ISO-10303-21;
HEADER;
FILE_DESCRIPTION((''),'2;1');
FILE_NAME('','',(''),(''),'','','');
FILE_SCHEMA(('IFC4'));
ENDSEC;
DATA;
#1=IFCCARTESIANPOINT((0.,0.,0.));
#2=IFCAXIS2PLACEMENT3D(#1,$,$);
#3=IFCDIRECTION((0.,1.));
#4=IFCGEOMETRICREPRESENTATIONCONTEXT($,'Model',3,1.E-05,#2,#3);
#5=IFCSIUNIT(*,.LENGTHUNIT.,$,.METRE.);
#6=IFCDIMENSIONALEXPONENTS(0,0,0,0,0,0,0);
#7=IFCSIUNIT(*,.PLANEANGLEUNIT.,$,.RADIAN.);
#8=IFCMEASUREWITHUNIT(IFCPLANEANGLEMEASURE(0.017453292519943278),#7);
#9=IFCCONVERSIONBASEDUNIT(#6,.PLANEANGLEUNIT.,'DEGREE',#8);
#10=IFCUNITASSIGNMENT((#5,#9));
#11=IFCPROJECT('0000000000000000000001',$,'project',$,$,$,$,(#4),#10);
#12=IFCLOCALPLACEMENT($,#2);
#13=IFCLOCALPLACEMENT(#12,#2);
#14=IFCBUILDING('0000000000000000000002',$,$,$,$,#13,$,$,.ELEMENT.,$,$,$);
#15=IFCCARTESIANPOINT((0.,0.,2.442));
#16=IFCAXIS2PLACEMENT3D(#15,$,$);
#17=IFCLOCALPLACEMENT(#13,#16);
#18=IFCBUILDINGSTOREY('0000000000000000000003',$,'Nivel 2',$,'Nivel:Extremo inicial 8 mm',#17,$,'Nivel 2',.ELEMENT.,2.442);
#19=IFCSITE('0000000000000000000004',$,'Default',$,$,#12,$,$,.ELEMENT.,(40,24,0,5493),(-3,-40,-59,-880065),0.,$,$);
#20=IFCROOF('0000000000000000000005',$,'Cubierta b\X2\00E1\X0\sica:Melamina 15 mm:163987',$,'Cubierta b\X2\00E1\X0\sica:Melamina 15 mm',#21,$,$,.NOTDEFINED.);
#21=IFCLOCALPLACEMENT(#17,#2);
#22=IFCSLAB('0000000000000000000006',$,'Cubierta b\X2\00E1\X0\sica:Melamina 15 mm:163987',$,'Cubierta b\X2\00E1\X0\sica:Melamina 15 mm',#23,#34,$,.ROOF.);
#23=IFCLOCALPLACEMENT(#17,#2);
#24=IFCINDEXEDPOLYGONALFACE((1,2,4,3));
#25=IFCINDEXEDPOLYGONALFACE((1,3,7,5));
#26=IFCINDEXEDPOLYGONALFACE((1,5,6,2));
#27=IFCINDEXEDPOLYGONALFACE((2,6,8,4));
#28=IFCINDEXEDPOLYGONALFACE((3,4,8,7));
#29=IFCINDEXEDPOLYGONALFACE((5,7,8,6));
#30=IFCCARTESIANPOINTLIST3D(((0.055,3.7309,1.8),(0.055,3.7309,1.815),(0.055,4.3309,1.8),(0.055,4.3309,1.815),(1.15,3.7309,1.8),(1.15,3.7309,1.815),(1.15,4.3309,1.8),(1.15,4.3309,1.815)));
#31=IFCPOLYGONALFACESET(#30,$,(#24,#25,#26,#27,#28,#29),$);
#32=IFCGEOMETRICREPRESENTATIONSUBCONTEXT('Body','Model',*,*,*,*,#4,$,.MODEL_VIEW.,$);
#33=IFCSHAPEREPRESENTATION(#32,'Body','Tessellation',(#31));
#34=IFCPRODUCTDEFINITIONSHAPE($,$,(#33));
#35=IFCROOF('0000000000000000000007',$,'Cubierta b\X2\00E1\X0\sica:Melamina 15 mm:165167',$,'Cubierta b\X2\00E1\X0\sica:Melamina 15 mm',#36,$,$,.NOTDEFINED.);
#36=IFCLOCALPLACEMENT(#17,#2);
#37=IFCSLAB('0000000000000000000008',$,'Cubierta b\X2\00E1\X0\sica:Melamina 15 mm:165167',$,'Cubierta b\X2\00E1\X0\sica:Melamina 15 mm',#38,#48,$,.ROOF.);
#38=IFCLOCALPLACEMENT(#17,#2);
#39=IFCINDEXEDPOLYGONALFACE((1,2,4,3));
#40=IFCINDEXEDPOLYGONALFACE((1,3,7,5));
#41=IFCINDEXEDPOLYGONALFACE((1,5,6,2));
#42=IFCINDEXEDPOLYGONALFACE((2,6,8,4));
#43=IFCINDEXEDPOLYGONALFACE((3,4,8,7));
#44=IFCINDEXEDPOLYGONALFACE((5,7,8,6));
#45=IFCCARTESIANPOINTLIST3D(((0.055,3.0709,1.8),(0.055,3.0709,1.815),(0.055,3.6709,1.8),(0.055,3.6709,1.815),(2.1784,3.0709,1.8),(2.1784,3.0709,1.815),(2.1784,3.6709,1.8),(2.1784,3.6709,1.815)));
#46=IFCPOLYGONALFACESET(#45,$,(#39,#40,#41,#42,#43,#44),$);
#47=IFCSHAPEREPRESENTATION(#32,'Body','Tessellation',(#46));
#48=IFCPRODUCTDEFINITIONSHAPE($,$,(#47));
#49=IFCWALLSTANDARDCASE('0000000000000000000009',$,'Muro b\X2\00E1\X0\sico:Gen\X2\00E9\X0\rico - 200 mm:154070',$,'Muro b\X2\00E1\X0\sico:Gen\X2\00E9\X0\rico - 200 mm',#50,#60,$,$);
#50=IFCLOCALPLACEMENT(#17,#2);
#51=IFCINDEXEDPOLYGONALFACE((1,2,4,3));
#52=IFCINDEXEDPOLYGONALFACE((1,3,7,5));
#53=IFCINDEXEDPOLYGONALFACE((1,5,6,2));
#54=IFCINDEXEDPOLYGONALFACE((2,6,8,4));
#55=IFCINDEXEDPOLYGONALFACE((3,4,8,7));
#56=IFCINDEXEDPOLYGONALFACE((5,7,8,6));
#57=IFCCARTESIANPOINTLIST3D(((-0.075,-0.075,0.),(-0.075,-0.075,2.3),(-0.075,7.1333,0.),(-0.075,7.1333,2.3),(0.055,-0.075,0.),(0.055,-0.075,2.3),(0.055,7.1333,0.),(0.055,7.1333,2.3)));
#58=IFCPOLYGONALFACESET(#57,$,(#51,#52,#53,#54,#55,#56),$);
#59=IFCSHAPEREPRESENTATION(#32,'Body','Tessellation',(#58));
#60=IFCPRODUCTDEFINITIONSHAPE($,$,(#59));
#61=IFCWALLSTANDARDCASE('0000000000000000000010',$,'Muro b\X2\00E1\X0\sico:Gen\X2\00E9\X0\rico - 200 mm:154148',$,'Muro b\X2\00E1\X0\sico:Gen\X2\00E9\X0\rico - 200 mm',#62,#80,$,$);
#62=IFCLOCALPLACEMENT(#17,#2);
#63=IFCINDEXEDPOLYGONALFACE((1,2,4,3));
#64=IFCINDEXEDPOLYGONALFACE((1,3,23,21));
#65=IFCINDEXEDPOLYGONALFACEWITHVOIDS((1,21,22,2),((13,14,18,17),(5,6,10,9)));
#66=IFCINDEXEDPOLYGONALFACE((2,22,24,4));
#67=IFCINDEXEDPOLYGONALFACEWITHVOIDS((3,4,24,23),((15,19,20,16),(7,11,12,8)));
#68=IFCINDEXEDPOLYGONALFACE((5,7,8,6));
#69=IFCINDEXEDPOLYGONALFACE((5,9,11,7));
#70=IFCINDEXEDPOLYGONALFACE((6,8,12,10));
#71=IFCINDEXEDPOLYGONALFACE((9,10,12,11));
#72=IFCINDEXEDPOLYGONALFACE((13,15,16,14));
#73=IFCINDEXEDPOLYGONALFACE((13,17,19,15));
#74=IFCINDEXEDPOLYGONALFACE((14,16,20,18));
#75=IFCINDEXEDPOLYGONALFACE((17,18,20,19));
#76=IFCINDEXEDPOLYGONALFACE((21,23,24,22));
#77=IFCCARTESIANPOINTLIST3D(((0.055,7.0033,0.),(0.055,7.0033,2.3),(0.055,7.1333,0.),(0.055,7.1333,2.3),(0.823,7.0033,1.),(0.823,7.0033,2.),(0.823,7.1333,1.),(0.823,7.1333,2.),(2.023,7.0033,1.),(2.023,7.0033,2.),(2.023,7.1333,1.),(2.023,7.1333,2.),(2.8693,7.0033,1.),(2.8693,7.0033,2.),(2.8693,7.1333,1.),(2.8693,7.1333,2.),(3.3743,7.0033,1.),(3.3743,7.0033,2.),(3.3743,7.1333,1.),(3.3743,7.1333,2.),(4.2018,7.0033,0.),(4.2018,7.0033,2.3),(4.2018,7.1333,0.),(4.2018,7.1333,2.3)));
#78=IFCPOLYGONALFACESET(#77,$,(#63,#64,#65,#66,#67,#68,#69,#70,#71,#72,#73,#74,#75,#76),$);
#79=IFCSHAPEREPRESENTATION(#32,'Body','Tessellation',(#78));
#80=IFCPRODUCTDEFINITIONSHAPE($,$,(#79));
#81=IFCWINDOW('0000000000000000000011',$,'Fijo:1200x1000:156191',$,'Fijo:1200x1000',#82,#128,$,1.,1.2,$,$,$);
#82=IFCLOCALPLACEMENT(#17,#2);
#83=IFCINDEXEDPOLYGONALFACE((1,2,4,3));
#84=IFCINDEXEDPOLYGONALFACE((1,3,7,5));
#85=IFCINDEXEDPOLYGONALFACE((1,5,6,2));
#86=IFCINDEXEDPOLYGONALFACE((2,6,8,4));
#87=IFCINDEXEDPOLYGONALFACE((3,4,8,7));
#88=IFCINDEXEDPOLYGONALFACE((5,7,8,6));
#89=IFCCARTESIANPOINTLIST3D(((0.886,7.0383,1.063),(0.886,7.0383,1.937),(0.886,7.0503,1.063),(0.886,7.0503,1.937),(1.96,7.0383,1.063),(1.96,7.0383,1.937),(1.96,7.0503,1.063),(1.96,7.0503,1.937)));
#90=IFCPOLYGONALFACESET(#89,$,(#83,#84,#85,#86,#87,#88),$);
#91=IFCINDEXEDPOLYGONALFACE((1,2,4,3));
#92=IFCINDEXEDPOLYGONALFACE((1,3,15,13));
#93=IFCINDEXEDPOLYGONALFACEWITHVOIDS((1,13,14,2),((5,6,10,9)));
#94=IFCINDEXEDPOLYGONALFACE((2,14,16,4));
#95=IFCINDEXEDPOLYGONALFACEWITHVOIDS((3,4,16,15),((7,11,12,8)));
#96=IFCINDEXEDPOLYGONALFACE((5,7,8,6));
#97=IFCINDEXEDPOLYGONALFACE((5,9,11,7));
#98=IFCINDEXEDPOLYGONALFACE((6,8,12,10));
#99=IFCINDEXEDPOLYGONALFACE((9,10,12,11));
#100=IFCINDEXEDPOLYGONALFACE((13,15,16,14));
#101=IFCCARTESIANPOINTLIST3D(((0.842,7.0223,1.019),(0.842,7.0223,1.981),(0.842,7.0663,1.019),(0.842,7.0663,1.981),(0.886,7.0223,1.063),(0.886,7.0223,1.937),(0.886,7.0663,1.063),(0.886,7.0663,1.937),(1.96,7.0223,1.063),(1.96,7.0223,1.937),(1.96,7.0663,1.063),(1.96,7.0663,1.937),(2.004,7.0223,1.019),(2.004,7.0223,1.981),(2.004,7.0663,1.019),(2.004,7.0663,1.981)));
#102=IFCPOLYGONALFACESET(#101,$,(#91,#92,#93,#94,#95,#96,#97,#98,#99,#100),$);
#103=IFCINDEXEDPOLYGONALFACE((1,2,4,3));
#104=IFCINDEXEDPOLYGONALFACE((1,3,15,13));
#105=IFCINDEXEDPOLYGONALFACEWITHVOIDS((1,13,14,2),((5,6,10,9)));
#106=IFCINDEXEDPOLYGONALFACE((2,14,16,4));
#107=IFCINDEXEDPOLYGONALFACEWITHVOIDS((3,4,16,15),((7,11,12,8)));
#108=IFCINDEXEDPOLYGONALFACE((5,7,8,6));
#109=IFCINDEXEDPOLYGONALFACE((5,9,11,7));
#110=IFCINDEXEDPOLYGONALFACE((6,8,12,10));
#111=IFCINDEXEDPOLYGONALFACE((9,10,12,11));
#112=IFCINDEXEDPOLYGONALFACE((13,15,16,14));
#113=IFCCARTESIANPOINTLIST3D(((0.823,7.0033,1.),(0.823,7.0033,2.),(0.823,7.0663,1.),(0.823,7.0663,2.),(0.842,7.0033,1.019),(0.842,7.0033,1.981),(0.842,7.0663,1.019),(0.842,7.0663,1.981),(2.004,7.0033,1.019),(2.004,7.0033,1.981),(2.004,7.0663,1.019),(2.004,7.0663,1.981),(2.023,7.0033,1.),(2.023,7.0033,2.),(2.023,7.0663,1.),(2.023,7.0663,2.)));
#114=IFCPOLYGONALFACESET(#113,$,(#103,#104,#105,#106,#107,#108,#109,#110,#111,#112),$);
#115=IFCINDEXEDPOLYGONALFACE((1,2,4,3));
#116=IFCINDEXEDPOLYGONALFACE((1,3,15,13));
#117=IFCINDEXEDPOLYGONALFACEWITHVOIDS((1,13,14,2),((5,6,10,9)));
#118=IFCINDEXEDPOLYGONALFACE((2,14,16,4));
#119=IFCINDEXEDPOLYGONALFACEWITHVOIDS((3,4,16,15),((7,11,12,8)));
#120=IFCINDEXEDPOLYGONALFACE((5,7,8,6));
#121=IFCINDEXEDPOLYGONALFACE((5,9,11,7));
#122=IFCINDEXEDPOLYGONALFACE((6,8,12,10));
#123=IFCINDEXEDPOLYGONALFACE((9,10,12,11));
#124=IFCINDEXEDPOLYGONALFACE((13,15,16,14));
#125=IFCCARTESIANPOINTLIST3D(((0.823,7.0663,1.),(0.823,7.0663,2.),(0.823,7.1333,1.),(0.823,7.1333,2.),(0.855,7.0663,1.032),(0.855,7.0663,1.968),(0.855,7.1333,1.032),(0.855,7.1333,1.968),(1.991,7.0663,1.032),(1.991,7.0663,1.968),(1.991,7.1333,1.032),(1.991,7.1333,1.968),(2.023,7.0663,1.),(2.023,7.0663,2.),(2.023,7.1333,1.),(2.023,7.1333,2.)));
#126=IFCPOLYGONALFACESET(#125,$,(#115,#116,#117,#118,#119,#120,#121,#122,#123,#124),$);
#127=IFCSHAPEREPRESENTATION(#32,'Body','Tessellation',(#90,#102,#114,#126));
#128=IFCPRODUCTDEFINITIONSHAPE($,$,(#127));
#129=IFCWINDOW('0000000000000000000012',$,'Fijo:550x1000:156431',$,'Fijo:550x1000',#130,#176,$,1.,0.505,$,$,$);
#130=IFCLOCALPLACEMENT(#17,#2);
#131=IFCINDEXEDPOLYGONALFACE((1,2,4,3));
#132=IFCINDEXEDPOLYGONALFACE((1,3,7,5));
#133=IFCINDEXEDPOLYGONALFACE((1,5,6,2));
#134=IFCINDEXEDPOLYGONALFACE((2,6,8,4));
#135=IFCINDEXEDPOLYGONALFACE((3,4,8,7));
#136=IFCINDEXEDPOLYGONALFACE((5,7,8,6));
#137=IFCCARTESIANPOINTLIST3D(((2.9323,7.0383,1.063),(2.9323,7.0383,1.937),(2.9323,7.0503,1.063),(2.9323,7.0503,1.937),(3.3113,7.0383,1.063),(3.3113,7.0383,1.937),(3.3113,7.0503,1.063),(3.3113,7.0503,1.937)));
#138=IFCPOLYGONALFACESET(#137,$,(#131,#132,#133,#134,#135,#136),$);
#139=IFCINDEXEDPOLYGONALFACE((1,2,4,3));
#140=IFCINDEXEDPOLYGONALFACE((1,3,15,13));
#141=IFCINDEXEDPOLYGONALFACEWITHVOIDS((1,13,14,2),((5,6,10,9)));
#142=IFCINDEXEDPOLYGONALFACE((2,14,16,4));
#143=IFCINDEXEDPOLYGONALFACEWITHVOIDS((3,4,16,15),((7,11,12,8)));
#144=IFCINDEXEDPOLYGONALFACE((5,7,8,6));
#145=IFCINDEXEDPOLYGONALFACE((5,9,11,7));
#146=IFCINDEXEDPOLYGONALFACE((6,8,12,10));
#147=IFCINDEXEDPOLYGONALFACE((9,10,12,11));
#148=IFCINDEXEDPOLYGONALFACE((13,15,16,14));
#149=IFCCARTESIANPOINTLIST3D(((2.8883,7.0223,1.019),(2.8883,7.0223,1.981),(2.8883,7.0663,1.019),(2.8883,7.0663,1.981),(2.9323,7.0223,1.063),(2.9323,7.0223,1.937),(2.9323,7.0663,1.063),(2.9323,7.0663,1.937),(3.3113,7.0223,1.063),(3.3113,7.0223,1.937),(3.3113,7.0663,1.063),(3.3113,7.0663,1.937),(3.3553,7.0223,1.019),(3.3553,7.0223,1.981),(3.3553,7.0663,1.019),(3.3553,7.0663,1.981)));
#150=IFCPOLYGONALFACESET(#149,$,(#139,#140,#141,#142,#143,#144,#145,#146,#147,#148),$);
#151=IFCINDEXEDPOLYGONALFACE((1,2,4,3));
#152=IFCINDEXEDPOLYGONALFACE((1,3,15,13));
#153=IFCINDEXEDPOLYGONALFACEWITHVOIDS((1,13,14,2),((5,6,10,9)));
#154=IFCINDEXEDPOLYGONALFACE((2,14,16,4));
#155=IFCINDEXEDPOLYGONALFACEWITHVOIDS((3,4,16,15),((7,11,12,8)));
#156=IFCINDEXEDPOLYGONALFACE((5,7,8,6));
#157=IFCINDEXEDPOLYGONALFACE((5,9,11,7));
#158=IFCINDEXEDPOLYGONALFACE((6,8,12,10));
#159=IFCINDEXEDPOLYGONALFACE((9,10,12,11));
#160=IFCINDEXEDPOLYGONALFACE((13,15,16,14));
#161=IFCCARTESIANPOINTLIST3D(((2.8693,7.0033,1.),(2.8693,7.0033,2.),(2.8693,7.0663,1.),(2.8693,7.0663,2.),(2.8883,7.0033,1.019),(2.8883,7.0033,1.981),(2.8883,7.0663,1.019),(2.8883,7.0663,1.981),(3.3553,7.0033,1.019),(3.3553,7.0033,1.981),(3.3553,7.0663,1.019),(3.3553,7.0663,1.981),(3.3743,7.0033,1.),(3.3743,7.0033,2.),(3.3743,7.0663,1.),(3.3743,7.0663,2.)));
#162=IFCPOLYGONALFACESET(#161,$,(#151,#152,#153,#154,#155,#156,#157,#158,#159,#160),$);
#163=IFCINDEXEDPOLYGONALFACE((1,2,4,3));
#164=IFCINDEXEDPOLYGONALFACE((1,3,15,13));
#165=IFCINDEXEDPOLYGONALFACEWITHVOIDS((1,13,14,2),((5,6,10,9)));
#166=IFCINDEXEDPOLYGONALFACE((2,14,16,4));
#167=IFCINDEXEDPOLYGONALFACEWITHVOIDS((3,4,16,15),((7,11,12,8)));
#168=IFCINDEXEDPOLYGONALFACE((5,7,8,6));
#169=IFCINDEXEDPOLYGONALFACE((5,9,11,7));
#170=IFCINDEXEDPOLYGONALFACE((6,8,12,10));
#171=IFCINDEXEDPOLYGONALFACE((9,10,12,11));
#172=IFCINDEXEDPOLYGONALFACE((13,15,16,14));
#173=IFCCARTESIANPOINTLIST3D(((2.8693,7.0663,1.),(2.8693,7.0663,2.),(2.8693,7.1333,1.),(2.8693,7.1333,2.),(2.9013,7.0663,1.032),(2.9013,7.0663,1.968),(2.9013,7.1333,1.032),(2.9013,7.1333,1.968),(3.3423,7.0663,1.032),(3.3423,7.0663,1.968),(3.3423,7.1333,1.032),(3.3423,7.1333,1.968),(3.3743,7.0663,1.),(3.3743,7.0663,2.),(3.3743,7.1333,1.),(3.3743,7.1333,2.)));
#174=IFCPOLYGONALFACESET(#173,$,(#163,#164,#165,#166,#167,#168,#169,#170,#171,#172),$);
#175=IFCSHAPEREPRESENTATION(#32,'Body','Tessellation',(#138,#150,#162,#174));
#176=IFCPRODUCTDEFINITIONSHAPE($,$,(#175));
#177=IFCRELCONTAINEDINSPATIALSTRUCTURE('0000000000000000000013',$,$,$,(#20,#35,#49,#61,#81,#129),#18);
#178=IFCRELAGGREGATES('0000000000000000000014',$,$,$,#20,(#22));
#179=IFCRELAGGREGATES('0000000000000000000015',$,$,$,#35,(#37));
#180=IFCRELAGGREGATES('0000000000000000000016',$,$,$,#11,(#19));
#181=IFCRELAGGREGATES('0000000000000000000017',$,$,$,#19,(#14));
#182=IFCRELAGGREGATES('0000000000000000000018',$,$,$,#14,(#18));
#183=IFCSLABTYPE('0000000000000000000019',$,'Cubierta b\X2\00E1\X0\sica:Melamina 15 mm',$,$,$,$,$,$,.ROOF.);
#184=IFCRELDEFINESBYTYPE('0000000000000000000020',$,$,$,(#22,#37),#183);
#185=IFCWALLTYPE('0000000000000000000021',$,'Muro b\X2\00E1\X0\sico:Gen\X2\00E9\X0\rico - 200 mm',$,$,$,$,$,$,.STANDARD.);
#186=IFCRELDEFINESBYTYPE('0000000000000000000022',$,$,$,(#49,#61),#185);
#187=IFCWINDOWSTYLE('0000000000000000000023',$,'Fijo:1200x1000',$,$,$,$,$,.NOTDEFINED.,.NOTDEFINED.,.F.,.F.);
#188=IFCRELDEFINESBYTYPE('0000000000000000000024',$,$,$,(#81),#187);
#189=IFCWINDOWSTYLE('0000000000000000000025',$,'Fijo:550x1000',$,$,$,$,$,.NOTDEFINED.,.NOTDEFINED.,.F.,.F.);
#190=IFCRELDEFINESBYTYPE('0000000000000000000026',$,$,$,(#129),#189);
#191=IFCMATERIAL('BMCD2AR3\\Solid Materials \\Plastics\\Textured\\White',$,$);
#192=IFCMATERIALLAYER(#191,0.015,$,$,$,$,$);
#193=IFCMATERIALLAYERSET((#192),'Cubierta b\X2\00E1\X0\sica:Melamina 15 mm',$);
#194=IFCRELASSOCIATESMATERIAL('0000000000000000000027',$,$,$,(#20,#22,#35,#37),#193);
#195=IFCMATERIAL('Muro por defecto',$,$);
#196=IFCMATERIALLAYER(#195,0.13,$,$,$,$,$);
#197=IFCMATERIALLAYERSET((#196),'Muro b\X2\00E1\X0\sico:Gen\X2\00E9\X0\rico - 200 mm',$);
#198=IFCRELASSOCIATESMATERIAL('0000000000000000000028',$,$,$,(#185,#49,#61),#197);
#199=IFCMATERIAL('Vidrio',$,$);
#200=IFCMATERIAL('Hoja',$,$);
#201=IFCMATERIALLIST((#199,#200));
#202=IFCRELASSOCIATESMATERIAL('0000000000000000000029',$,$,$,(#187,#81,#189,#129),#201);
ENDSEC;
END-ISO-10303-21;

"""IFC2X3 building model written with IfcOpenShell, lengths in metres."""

from ifc_helpers import new_model, entity, si_unit, converted_unit, direction, frame, frame_2d, origin, origin_2d_with_axis, place, context, subcontext, project, spatial, polyline, rectangle, outline, extrude, source, transform, mapped, material, material_list, layer, layer_set, layer_usage, type_object, type_shapes, element, fill, aggregate, save


model = new_model("IFC2X3")

# Units and contexts
model_context = context("Model", 3, precision=1e-05, world=origin(), true_north=direction((0.0, 1.0)))
body_context = subcontext(model_context, "Body", "Model", "MODEL_VIEW")
ifc_project = project(units=[si_unit("LENGTHUNIT", "METRE"), converted_unit("PLANEANGLEUNIT", "DEGREE", entity("IfcPlaneAngleMeasure", 0.017453292519943278), si_unit("PLANEANGLEUNIT", "RADIAN"), dimensions=[0, 0, 0, 0, 0, 0, 0])], contexts=[model_context])

# Site, building, storey
site_placement = place(None, origin())
site = spatial("IfcSite", under=ifc_project, at=site_placement, Name="Default", CompositionType="ELEMENT", RefLatitude=(40, 24, 0, 5493), RefLongitude=(-3, -40, -59, -880065), RefElevation=0.0)
building_placement = place(site_placement, origin())
building = spatial("IfcBuilding", under=site, at=building_placement, CompositionType="ELEMENT")
storey_placement = place(building_placement, frame((0.0, 0.0, 2.442)))
storey = spatial("IfcBuildingStorey", under=building, at=storey_placement, Name="Nivel 2", ObjectType="Nivel:Extremo inicial 8 mm", LongName="Nivel 2", CompositionType="ELEMENT", Elevation=2.442)

# Roofs, slabs
ifc_material_1 = material(Name="BMCD2AR3\\Solid Materials \\Plastics\\Textured\\White")
ifc_layer_1 = layer(ifc_material_1, 0.015)
ifc_layer_set_1 = layer_set([ifc_layer_1], Name="Cubierta básica:Melamina 15 mm")
roof_1_placement = place(storey_placement, frame((0.055, 3.7309, 1.8)))
roof_1 = element("IfcRoof", 1, at=roof_1_placement, inside=storey, material=ifc_layer_set_1, Name="Cubierta básica:Melamina 15 mm:163987", ObjectType="Cubierta básica:Melamina 15 mm", ShapeType="NOTDEFINED")
slab_type_1 = type_object("IfcSlabType", Name="Cubierta básica:Melamina 15 mm", PredefinedType="ROOF")
slab_1_placement = place(roof_1_placement, origin())
slab_1 = element("IfcSlab", 2, at=slab_1_placement, type_object=slab_type_1, material=ifc_layer_set_1, Name="Cubierta básica:Melamina 15 mm:163987", ObjectType="Cubierta básica:Melamina 15 mm", PredefinedType="ROOF", context=body_context, shape_type="SweptSolid", body=[
    extrude(rectangle(XDim=1.095, YDim=0.6, at=frame_2d((0.0, 0.0), x_axis=(1.0, 0.0))), frame((0.5475, 0.3, 0.0)), (0.0, 0.0, 1.0), 0.015),
])
aggregate(roof_1, [slab_1])
roof_2_placement = place(storey_placement, frame((0.055, 3.0709, 1.8)))
roof_2 = element("IfcRoof", 3, at=roof_2_placement, inside=storey, material=ifc_layer_set_1, Name="Cubierta básica:Melamina 15 mm:165167", ObjectType="Cubierta básica:Melamina 15 mm", ShapeType="NOTDEFINED")
slab_2_placement = place(roof_2_placement, origin())
slab_2 = element("IfcSlab", 4, at=slab_2_placement, type_object=slab_type_1, material=ifc_layer_set_1, Name="Cubierta básica:Melamina 15 mm:165167", ObjectType="Cubierta básica:Melamina 15 mm", PredefinedType="ROOF", context=body_context, shape_type="SweptSolid", body=[
    extrude(rectangle(XDim=2.1234, YDim=0.6, at=origin_2d_with_axis()), frame((1.0617, 0.3, 0.0)), (0.0, 0.0, 1.0), 0.015),
])
aggregate(roof_2, [slab_2])

# Wall
ifc_material_2 = material(Name="Muro por defecto")
ifc_layer_2 = layer(ifc_material_2, 0.13)
ifc_layer_set_2 = layer_set([ifc_layer_2], Name="Muro básico:Genérico - 200 mm")
ifc_layer_usage_1 = layer_usage(ifc_layer_set_2, "AXIS2", "NEGATIVE", 0.065)
wall_type_1 = type_object("IfcWallType", Name="Muro básico:Genérico - 200 mm", PredefinedType="STANDARD", material=ifc_layer_set_2)
wall_1_placement = place(storey_placement, frame((-0.01, -0.075, 0.0), z_axis=(0.0, 0.0, 1.0), x_axis=(0.0, 1.0, 0.0)))
element("IfcWallStandardCase", 5, at=wall_1_placement, inside=storey, type_object=wall_type_1, material=ifc_layer_usage_1, Name="Muro básico:Genérico - 200 mm:154070", ObjectType="Muro básico:Genérico - 200 mm", context=body_context, shape_type="SweptSolid", body=[
    extrude(rectangle(XDim=7.2083, YDim=0.13, at=frame_2d((3.6042, 0.0), x_axis=(-1.0, 0.0))), origin(), (0.0, 0.0, 1.0), 2.3),
])

# Wall, openings, windows
ifc_layer_usage_2 = layer_usage(ifc_layer_set_2, "AXIS2", "NEGATIVE", 0.065)
wall_2_placement = place(storey_placement, frame((0.055, 7.0683, 0.0)))
wall_2 = element("IfcWallStandardCase", 6, at=wall_2_placement, inside=storey, type_object=wall_type_1, material=ifc_layer_usage_2, Name="Muro básico:Genérico - 200 mm:154148", ObjectType="Muro básico:Genérico - 200 mm", context=body_context, shape_type="SweptSolid", body=[
    extrude(rectangle(XDim=4.1468, YDim=0.13, at=frame_2d((2.0734, 0.0), x_axis=(-1.0, 0.0))), origin(), (0.0, 0.0, 1.0), 2.3),
])
opening_1_placement = place(wall_2_placement, frame((1.968, 0.065, 1.0)))
opening_1 = element("IfcOpeningElement", 7, at=opening_1_placement, cuts=wall_2, ObjectType="Opening", context=body_context, shape_type="SweptSolid", body=[
    extrude(rectangle(XDim=1.0, YDim=1.2, at=frame_2d((0.5, 0.6), x_axis=(1.0, 0.0))), frame((0.0, 0.0, 0.0), z_axis=(0.0, -1.0, 0.0), x_axis=(0.0, 0.0, 1.0)), (0.0, 0.0, 1.0), 0.13),
])
opening_2_placement = place(wall_2_placement, frame((3.3193, 0.065, 1.0)))
opening_2 = element("IfcOpeningElement", 8, at=opening_2_placement, cuts=wall_2, ObjectType="Opening", context=body_context, shape_type="SweptSolid", body=[
    extrude(rectangle(XDim=1.0, YDim=0.505, at=frame_2d((0.5, 0.2525), x_axis=(1.0, 0.0))), frame((0.0, 0.0, 0.0), z_axis=(0.0, -1.0, 0.0), x_axis=(0.0, 0.0, 1.0)), (0.0, 0.0, 1.0), 0.13),
])
ifc_material_3 = material(Name="Vidrio")
ifc_material_4 = material(Name="Hoja")
ifc_material_list_1 = material_list([ifc_material_3, ifc_material_4])
window_style_1 = type_object("IfcWindowStyle", Name="Fijo:1200x1000", ConstructionType="NOTDEFINED", OperationType="NOTDEFINED", ParameterTakesPrecedence=False, Sizeable=False, material=ifc_material_list_1)
shared_shape_1 = source(origin(), body_context, "Body", "SweptSolid", [
    extrude(rectangle(XDim=0.012, YDim=1.074, at=origin_2d_with_axis()), frame((0.6, 0.089, 0.063), z_axis=(0.0, 0.0, 1.0), x_axis=(0.0, -1.0, 0.0)), (0.0, 0.0, 1.0), 0.874),
    extrude(outline(polyline([(-0.581, -0.481), (0.581, -0.481), (0.581, 0.481), (-0.581, 0.481), (-0.581, -0.481)]), holes=[polyline([(-0.537, -0.437), (-0.537, 0.437), (0.537, 0.437), (0.537, -0.437), (-0.537, -0.437)])]), frame((0.6, 0.067, 0.5), z_axis=(0.0, 1.0, 0.0), x_axis=(1.0, 0.0, 0.0)), (0.0, 0.0, 1.0), 0.044),
    extrude(outline(polyline([(-0.6, -0.5), (0.6, -0.5), (0.6, 0.5), (-0.6, 0.5), (-0.6, -0.5)]), holes=[polyline([(-0.581, -0.481), (-0.581, 0.481), (0.581, 0.481), (0.581, -0.481), (-0.581, -0.481)])]), frame((0.6, 0.067, 0.5), z_axis=(0.0, 1.0, 0.0), x_axis=(1.0, 0.0, 0.0)), (0.0, 0.0, 1.0), 0.063),
    extrude(outline(polyline([(-0.6, -0.5), (0.6, -0.5), (0.6, 0.5), (-0.6, 0.5), (-0.6, -0.5)]), holes=[polyline([(-0.568, -0.468), (-0.568, 0.468), (0.568, 0.468), (0.568, -0.468), (-0.568, -0.468)])]), frame((0.6, 0.0, 0.5), z_axis=(0.0, 1.0, 0.0), x_axis=(1.0, 0.0, 0.0)), (0.0, 0.0, 1.0), 0.067),
])
type_shapes(window_style_1, [shared_shape_1])
window_1_placement = place(opening_1_placement, frame((0.0, 0.0, 0.0), z_axis=(0.0, 0.0, 1.0), x_axis=(-1.0, 0.0, 0.0)))
window_1 = element("IfcWindow", 9, at=window_1_placement, inside=storey, type_object=window_style_1, material=ifc_material_list_1, Name="Fijo:1200x1000:156191", ObjectType="Fijo:1200x1000", OverallHeight=1.0, OverallWidth=1.2, context=body_context, shape_type="MappedRepresentation", body=[
    mapped(shared_shape_1, transform((0.0, 0.0, 0.0), scale=1.0)),
])
fill(opening_1, window_1)
window_style_2 = type_object("IfcWindowStyle", Name="Fijo:550x1000", ConstructionType="NOTDEFINED", OperationType="NOTDEFINED", ParameterTakesPrecedence=False, Sizeable=False, material=ifc_material_list_1)
shared_shape_2 = source(origin(), body_context, "Body", "SweptSolid", [
    extrude(rectangle(XDim=0.012, YDim=0.379, at=origin_2d_with_axis()), frame((0.2525, 0.089, 0.063), z_axis=(0.0, 0.0, 1.0), x_axis=(0.0, -1.0, 0.0)), (0.0, 0.0, 1.0), 0.874),
    extrude(outline(polyline([(-0.2335, -0.481), (0.2335, -0.481), (0.2335, 0.481), (-0.2335, 0.481), (-0.2335, -0.481)]), holes=[polyline([(-0.1895, -0.437), (-0.1895, 0.437), (0.1895, 0.437), (0.1895, -0.437), (-0.1895, -0.437)])]), frame((0.2525, 0.067, 0.5), z_axis=(0.0, 1.0, 0.0), x_axis=(1.0, 0.0, 0.0)), (0.0, 0.0, 1.0), 0.044),
    extrude(outline(polyline([(-0.2525, -0.5), (0.2525, -0.5), (0.2525, 0.5), (-0.2525, 0.5), (-0.2525, -0.5)]), holes=[polyline([(-0.2335, -0.481), (-0.2335, 0.481), (0.2335, 0.481), (0.2335, -0.481), (-0.2335, -0.481)])]), frame((0.2525, 0.067, 0.5), z_axis=(0.0, 1.0, 0.0), x_axis=(1.0, 0.0, 0.0)), (0.0, 0.0, 1.0), 0.063),
    extrude(outline(polyline([(-0.2525, -0.5), (0.2525, -0.5), (0.2525, 0.5), (-0.2525, 0.5), (-0.2525, -0.5)]), holes=[polyline([(-0.2205, -0.468), (-0.2205, 0.468), (0.2205, 0.468), (0.2205, -0.468), (-0.2205, -0.468)])]), frame((0.2525, 0.0, 0.5), z_axis=(0.0, 1.0, 0.0), x_axis=(1.0, 0.0, 0.0)), (0.0, 0.0, 1.0), 0.067),
])
type_shapes(window_style_2, [shared_shape_2])
window_2_placement = place(opening_2_placement, frame((0.0, 0.0, 0.0), z_axis=(0.0, 0.0, 1.0), x_axis=(-1.0, 0.0, 0.0)))
window_2 = element("IfcWindow", 10, at=window_2_placement, inside=storey, type_object=window_style_2, material=ifc_material_list_1, Name="Fijo:550x1000:156431", ObjectType="Fijo:550x1000", OverallHeight=1.0, OverallWidth=0.505, context=body_context, shape_type="MappedRepresentation", body=[
    mapped(shared_shape_2, transform((0.0, 0.0, 0.0), scale=1.0)),
])
fill(opening_2, window_2)

save(model, "model.ifc")
